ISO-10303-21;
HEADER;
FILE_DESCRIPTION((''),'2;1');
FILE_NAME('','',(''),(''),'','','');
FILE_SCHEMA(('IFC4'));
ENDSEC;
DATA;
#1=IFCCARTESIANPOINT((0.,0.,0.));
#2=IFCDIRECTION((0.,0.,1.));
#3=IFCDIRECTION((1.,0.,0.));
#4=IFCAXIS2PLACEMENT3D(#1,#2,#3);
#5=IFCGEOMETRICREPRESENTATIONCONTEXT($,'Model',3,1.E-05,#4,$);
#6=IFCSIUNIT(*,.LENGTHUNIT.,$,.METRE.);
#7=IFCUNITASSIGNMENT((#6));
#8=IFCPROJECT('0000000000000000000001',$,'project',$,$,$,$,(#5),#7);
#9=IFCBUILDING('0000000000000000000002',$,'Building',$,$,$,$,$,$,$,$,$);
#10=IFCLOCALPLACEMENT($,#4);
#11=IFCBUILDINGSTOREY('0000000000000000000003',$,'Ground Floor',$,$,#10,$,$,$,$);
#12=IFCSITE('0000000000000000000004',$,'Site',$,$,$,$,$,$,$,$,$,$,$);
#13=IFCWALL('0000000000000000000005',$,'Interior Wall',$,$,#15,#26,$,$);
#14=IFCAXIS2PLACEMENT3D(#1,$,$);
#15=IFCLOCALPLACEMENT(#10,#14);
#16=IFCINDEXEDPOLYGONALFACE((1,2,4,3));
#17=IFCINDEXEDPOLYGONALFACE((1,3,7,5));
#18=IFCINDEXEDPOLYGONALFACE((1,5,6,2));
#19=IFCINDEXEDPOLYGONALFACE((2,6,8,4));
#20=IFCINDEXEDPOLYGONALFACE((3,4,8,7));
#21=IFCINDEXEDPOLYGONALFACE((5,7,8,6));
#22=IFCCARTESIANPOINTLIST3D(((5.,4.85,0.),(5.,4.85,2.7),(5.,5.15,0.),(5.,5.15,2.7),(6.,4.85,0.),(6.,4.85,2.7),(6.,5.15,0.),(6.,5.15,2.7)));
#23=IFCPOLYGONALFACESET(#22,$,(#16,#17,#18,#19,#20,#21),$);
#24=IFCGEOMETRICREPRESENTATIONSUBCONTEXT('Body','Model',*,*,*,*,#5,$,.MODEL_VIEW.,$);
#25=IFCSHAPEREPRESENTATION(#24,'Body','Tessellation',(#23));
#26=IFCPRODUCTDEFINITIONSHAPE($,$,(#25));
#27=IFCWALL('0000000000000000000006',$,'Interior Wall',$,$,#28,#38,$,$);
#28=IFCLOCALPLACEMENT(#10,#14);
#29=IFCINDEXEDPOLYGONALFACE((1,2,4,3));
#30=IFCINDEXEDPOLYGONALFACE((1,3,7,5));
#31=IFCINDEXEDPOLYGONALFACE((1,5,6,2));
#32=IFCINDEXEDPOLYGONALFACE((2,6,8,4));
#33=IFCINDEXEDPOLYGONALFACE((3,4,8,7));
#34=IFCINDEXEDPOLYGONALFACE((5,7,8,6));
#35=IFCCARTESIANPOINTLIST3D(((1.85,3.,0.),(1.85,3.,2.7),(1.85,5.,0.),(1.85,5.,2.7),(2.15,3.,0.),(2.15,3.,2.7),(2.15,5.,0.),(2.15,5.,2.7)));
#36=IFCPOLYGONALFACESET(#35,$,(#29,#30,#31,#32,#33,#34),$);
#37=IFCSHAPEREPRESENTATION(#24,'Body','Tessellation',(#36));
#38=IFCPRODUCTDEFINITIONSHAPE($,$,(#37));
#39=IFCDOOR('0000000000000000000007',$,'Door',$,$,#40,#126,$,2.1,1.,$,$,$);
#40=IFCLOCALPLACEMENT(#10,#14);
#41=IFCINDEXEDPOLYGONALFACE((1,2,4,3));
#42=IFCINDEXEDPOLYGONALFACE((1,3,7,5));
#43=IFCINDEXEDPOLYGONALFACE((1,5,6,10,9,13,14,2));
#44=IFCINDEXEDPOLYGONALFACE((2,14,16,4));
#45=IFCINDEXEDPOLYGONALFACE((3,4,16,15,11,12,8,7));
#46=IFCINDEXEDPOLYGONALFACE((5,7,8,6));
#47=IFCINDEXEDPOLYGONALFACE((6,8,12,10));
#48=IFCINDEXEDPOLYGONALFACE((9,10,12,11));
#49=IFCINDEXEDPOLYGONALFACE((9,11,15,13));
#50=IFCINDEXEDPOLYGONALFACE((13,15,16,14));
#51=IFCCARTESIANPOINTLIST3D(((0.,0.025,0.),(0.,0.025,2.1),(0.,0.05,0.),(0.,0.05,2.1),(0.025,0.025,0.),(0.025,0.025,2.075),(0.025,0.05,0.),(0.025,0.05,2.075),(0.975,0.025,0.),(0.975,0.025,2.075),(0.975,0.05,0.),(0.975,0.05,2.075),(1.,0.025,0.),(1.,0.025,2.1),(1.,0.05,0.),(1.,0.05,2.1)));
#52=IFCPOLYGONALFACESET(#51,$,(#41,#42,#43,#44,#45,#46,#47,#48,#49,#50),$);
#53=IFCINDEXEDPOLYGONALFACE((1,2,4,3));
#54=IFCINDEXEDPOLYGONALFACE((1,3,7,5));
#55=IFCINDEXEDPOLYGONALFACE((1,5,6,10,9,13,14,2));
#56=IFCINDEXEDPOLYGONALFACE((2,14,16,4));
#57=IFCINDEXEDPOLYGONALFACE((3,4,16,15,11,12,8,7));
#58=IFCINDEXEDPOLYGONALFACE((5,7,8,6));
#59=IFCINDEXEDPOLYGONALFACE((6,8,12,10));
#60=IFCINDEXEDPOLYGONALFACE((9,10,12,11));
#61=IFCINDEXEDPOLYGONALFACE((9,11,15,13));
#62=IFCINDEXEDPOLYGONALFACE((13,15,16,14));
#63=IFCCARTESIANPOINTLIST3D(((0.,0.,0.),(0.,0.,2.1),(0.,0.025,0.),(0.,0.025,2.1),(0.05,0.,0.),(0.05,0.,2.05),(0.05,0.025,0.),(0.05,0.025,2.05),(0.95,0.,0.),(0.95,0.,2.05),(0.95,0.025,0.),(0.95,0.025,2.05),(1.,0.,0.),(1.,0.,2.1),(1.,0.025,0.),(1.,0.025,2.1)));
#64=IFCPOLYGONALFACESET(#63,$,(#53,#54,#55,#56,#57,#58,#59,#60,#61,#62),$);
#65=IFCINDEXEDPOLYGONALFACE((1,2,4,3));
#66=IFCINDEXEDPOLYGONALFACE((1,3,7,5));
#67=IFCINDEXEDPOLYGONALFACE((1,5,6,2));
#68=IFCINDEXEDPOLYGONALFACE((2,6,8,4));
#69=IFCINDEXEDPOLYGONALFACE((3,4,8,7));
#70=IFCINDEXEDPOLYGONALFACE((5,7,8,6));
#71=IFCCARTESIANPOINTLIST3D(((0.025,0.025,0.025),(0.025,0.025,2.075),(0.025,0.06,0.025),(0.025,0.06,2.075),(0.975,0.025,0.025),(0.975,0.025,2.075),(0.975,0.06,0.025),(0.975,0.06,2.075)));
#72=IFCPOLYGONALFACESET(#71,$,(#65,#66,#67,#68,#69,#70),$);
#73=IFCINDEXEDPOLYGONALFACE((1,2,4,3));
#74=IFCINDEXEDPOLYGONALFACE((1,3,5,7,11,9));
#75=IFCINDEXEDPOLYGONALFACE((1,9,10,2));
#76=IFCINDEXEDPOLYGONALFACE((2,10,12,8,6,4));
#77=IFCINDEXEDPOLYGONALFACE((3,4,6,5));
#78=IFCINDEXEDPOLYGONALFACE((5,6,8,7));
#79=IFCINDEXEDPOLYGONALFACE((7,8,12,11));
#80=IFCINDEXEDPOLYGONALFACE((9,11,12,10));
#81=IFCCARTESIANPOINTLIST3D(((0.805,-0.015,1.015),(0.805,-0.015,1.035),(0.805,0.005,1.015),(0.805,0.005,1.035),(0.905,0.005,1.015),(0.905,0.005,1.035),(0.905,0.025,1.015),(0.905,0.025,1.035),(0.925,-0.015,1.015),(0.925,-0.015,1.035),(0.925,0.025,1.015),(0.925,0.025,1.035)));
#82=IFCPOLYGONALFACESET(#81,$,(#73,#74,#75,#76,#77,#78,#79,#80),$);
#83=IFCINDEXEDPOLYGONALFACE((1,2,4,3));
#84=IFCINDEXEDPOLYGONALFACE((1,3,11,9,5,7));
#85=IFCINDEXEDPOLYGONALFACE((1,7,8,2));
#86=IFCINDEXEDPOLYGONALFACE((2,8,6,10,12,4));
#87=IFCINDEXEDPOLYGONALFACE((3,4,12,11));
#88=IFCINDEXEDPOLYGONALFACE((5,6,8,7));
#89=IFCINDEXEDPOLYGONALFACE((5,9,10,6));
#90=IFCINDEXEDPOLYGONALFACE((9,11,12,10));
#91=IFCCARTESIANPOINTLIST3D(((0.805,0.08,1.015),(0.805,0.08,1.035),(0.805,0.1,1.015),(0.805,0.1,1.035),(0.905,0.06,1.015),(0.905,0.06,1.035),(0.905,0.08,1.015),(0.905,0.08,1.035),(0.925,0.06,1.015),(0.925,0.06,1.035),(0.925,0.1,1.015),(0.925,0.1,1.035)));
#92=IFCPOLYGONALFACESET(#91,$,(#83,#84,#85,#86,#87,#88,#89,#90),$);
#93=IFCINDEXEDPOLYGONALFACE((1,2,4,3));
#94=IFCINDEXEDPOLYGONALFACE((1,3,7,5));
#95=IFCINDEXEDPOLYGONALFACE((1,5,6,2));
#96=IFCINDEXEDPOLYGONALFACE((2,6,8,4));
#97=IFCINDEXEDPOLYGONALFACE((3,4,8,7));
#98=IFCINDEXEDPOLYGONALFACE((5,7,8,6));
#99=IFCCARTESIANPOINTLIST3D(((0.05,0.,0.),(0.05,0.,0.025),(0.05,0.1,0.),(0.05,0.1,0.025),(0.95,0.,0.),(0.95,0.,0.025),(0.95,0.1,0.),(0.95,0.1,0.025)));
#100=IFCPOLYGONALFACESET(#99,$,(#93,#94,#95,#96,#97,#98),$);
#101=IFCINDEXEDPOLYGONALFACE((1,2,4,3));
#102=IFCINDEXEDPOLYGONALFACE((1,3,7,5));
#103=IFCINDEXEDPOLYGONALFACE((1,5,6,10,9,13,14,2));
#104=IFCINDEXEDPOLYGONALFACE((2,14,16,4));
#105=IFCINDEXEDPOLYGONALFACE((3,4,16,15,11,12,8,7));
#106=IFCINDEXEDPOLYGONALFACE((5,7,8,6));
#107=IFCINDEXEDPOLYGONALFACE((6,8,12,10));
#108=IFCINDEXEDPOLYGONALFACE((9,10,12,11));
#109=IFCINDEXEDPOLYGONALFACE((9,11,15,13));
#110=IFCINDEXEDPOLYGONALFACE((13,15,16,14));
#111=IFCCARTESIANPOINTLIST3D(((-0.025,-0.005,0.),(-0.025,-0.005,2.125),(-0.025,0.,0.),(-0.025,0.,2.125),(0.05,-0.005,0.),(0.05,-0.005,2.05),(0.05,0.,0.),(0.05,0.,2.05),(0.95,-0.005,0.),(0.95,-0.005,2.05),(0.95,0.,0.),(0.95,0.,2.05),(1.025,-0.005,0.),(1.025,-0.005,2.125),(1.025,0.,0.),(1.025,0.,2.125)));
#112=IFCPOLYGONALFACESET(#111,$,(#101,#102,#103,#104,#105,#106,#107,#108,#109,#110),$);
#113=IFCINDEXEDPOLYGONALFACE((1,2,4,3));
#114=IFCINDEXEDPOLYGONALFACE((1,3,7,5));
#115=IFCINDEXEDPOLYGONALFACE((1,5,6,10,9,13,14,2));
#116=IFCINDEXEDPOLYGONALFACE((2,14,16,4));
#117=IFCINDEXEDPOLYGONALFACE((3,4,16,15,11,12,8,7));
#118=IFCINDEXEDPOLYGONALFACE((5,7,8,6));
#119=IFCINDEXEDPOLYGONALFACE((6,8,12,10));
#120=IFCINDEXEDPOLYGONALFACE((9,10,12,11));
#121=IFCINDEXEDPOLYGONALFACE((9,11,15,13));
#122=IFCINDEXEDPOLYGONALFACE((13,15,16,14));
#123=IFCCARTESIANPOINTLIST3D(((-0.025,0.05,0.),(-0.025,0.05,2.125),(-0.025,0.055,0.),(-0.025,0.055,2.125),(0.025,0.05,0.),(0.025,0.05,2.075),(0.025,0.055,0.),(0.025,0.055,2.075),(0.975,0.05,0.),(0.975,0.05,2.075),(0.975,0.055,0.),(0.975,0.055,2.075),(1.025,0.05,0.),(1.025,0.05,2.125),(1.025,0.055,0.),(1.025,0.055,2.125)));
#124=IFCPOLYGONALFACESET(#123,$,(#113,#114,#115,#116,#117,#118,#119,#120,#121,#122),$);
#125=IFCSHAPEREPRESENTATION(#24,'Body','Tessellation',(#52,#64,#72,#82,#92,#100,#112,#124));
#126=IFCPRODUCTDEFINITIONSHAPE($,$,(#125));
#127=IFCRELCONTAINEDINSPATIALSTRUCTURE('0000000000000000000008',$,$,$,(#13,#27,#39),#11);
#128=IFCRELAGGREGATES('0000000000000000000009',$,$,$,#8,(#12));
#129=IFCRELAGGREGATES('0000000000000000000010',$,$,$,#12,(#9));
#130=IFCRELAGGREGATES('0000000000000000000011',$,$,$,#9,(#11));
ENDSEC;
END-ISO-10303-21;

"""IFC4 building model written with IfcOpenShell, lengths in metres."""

from ifc_helpers import new_model, si_unit, frame, origin_with_axes, place, context, subcontext, project, spatial, line, indexed_curve, outline, extrude, element, save


model = new_model("IFC4")

# Units and contexts
model_context = context("Model", 3, precision=1e-05, world=origin_with_axes())
body_context = subcontext(model_context, "Body", "Model", "MODEL_VIEW")
ifc_project = project(units=[si_unit("LENGTHUNIT", "METRE")], contexts=[model_context])

# Site, building, storey
site = spatial("IfcSite", under=ifc_project, Name="Site")
building = spatial("IfcBuilding", under=site, Name="Building")
storey_placement = place(None, origin_with_axes())
storey = spatial("IfcBuildingStorey", under=building, at=storey_placement, Name="Ground Floor")

# Walls
wall_1_placement = place(storey_placement, frame((6.0, 5.0, 0.0), z_axis=(0.0, 0.0, 1.0), x_axis=(-1.0, 0.0, 0.0)))
element("IfcWall", 1, at=wall_1_placement, inside=storey, Name="Interior Wall", context=body_context, shape_type="SweptSolid", body=[
    extrude(outline(indexed_curve([(0.0, 0.0), (0.0, 0.3), (1.0, 0.3), (1.0, 0.0), (0.0, 0.0)], self_intersect=False)), frame((0.0, -0.15, 0.0), z_axis=(0.0, 0.0, 1.0), x_axis=(1.0, 0.0, 0.0)), (0.0, 0.0, 1.0), 2.7),
])
wall_2_placement = place(storey_placement, frame((2.0, 5.0, 0.0), z_axis=(0.0, 0.0, 1.0), x_axis=(0.0, -1.0, 0.0)))
element("IfcWall", 2, at=wall_2_placement, inside=storey, Name="Interior Wall", context=body_context, shape_type="SweptSolid", body=[
    extrude(outline(indexed_curve([(0.0, 0.0), (0.0, 0.3), (2.0, 0.3), (2.0, 0.0), (0.0, 0.0)], self_intersect=False)), frame((0.0, -0.15, 0.0), z_axis=(0.0, 0.0, 1.0), x_axis=(1.0, 0.0, 0.0)), (0.0, 0.0, 1.0), 2.7),
])

# Door
door_1_placement = place(storey_placement, origin_with_axes())
element("IfcDoor", 3, at=door_1_placement, inside=storey, Name="Door", OverallHeight=2.1, OverallWidth=1.0, context=body_context, shape_type="SweptSolid", body=[
    extrude(outline(indexed_curve([(0.0, 0.0), (0.0, 2.1), (1.0, 2.1), (1.0, 0.0), (0.975, 0.0), (0.975, 2.075), (0.025, 2.075), (0.025, 0.0)], segments=[line(1, 2, 3, 4, 5, 6, 7, 8, 1)])), frame((0.0, 0.025, 0.0), z_axis=(0.0, -1.0, 0.0), x_axis=(1.0, 0.0, 0.0)), (0.0, 0.0, -1.0), 0.025),
    extrude(outline(indexed_curve([(0.0, 0.0), (0.0, 2.1), (1.0, 2.1), (1.0, 0.0), (0.95, 0.0), (0.95, 2.05), (0.05, 2.05), (0.05, 0.0)], segments=[line(1, 2, 3, 4, 5, 6, 7, 8, 1)])), frame((0.0, 0.0, 0.0), z_axis=(0.0, -1.0, 0.0), x_axis=(1.0, 0.0, 0.0)), (0.0, 0.0, -1.0), 0.025),
    extrude(outline(indexed_curve([(0.0, 0.0), (0.95, 0.0), (0.95, 0.035), (0.0, 0.035)], segments=[line(1, 2, 3, 4, 1)])), frame((0.025, 0.025, 0.025), z_axis=(0.0, 0.0, 1.0), x_axis=(1.0, 0.0, 0.0)), (0.0, 0.0, 1.0), 2.05),
    extrude(outline(indexed_curve([(0.0, 0.0), (0.0, -0.04), (-0.12, -0.04), (-0.12, -0.02), (-0.02, -0.02), (-0.02, 0.0)], segments=[line(1, 2, 3, 4, 5, 6, 1)])), frame((0.925, 0.025, 1.015), z_axis=(0.0, 0.0, 1.0), x_axis=(1.0, 0.0, 0.0)), (0.0, 0.0, 1.0), 0.02),
    extrude(outline(indexed_curve([(0.0, 0.0), (0.0, 0.04), (-0.12, 0.04), (-0.12, 0.02), (-0.02, 0.02), (-0.02, 0.0)], segments=[line(1, 2, 3, 4, 5, 6, 1)])), frame((0.925, 0.06, 1.015), z_axis=(0.0, 0.0, 1.0), x_axis=(1.0, 0.0, 0.0)), (0.0, 0.0, 1.0), 0.02),
    extrude(outline(indexed_curve([(0.0, 0.0), (0.9, 0.0), (0.9, 0.1), (0.0, 0.1)], segments=[line(1, 2, 3, 4, 1)])), frame((0.05, 0.0, 0.0), z_axis=(0.0, 0.0, 1.0), x_axis=(1.0, 0.0, 0.0)), (0.0, 0.0, 1.0), 0.025),
    extrude(outline(indexed_curve([(0.0, 0.0), (0.0, 2.125), (1.05, 2.125), (1.05, 0.0), (0.975, 0.0), (0.975, 2.05), (0.075, 2.05), (0.075, 0.0)], segments=[line(1, 2, 3, 4, 5, 6, 7, 8, 1)])), frame((-0.025, -0.005, 0.0), z_axis=(0.0, -1.0, 0.0), x_axis=(1.0, 0.0, 0.0)), (0.0, 0.0, -1.0), 0.005),
    extrude(outline(indexed_curve([(0.0, 0.0), (0.0, 2.125), (1.05, 2.125), (1.05, 0.0), (1.0, 0.0), (1.0, 2.075), (0.05, 2.075), (0.05, 0.0)], segments=[line(1, 2, 3, 4, 5, 6, 7, 8, 1)])), frame((-0.025, 0.05, 0.0), z_axis=(0.0, -1.0, 0.0), x_axis=(1.0, 0.0, 0.0)), (0.0, 0.0, -1.0), 0.005),
])

save(model, "model.ifc")
